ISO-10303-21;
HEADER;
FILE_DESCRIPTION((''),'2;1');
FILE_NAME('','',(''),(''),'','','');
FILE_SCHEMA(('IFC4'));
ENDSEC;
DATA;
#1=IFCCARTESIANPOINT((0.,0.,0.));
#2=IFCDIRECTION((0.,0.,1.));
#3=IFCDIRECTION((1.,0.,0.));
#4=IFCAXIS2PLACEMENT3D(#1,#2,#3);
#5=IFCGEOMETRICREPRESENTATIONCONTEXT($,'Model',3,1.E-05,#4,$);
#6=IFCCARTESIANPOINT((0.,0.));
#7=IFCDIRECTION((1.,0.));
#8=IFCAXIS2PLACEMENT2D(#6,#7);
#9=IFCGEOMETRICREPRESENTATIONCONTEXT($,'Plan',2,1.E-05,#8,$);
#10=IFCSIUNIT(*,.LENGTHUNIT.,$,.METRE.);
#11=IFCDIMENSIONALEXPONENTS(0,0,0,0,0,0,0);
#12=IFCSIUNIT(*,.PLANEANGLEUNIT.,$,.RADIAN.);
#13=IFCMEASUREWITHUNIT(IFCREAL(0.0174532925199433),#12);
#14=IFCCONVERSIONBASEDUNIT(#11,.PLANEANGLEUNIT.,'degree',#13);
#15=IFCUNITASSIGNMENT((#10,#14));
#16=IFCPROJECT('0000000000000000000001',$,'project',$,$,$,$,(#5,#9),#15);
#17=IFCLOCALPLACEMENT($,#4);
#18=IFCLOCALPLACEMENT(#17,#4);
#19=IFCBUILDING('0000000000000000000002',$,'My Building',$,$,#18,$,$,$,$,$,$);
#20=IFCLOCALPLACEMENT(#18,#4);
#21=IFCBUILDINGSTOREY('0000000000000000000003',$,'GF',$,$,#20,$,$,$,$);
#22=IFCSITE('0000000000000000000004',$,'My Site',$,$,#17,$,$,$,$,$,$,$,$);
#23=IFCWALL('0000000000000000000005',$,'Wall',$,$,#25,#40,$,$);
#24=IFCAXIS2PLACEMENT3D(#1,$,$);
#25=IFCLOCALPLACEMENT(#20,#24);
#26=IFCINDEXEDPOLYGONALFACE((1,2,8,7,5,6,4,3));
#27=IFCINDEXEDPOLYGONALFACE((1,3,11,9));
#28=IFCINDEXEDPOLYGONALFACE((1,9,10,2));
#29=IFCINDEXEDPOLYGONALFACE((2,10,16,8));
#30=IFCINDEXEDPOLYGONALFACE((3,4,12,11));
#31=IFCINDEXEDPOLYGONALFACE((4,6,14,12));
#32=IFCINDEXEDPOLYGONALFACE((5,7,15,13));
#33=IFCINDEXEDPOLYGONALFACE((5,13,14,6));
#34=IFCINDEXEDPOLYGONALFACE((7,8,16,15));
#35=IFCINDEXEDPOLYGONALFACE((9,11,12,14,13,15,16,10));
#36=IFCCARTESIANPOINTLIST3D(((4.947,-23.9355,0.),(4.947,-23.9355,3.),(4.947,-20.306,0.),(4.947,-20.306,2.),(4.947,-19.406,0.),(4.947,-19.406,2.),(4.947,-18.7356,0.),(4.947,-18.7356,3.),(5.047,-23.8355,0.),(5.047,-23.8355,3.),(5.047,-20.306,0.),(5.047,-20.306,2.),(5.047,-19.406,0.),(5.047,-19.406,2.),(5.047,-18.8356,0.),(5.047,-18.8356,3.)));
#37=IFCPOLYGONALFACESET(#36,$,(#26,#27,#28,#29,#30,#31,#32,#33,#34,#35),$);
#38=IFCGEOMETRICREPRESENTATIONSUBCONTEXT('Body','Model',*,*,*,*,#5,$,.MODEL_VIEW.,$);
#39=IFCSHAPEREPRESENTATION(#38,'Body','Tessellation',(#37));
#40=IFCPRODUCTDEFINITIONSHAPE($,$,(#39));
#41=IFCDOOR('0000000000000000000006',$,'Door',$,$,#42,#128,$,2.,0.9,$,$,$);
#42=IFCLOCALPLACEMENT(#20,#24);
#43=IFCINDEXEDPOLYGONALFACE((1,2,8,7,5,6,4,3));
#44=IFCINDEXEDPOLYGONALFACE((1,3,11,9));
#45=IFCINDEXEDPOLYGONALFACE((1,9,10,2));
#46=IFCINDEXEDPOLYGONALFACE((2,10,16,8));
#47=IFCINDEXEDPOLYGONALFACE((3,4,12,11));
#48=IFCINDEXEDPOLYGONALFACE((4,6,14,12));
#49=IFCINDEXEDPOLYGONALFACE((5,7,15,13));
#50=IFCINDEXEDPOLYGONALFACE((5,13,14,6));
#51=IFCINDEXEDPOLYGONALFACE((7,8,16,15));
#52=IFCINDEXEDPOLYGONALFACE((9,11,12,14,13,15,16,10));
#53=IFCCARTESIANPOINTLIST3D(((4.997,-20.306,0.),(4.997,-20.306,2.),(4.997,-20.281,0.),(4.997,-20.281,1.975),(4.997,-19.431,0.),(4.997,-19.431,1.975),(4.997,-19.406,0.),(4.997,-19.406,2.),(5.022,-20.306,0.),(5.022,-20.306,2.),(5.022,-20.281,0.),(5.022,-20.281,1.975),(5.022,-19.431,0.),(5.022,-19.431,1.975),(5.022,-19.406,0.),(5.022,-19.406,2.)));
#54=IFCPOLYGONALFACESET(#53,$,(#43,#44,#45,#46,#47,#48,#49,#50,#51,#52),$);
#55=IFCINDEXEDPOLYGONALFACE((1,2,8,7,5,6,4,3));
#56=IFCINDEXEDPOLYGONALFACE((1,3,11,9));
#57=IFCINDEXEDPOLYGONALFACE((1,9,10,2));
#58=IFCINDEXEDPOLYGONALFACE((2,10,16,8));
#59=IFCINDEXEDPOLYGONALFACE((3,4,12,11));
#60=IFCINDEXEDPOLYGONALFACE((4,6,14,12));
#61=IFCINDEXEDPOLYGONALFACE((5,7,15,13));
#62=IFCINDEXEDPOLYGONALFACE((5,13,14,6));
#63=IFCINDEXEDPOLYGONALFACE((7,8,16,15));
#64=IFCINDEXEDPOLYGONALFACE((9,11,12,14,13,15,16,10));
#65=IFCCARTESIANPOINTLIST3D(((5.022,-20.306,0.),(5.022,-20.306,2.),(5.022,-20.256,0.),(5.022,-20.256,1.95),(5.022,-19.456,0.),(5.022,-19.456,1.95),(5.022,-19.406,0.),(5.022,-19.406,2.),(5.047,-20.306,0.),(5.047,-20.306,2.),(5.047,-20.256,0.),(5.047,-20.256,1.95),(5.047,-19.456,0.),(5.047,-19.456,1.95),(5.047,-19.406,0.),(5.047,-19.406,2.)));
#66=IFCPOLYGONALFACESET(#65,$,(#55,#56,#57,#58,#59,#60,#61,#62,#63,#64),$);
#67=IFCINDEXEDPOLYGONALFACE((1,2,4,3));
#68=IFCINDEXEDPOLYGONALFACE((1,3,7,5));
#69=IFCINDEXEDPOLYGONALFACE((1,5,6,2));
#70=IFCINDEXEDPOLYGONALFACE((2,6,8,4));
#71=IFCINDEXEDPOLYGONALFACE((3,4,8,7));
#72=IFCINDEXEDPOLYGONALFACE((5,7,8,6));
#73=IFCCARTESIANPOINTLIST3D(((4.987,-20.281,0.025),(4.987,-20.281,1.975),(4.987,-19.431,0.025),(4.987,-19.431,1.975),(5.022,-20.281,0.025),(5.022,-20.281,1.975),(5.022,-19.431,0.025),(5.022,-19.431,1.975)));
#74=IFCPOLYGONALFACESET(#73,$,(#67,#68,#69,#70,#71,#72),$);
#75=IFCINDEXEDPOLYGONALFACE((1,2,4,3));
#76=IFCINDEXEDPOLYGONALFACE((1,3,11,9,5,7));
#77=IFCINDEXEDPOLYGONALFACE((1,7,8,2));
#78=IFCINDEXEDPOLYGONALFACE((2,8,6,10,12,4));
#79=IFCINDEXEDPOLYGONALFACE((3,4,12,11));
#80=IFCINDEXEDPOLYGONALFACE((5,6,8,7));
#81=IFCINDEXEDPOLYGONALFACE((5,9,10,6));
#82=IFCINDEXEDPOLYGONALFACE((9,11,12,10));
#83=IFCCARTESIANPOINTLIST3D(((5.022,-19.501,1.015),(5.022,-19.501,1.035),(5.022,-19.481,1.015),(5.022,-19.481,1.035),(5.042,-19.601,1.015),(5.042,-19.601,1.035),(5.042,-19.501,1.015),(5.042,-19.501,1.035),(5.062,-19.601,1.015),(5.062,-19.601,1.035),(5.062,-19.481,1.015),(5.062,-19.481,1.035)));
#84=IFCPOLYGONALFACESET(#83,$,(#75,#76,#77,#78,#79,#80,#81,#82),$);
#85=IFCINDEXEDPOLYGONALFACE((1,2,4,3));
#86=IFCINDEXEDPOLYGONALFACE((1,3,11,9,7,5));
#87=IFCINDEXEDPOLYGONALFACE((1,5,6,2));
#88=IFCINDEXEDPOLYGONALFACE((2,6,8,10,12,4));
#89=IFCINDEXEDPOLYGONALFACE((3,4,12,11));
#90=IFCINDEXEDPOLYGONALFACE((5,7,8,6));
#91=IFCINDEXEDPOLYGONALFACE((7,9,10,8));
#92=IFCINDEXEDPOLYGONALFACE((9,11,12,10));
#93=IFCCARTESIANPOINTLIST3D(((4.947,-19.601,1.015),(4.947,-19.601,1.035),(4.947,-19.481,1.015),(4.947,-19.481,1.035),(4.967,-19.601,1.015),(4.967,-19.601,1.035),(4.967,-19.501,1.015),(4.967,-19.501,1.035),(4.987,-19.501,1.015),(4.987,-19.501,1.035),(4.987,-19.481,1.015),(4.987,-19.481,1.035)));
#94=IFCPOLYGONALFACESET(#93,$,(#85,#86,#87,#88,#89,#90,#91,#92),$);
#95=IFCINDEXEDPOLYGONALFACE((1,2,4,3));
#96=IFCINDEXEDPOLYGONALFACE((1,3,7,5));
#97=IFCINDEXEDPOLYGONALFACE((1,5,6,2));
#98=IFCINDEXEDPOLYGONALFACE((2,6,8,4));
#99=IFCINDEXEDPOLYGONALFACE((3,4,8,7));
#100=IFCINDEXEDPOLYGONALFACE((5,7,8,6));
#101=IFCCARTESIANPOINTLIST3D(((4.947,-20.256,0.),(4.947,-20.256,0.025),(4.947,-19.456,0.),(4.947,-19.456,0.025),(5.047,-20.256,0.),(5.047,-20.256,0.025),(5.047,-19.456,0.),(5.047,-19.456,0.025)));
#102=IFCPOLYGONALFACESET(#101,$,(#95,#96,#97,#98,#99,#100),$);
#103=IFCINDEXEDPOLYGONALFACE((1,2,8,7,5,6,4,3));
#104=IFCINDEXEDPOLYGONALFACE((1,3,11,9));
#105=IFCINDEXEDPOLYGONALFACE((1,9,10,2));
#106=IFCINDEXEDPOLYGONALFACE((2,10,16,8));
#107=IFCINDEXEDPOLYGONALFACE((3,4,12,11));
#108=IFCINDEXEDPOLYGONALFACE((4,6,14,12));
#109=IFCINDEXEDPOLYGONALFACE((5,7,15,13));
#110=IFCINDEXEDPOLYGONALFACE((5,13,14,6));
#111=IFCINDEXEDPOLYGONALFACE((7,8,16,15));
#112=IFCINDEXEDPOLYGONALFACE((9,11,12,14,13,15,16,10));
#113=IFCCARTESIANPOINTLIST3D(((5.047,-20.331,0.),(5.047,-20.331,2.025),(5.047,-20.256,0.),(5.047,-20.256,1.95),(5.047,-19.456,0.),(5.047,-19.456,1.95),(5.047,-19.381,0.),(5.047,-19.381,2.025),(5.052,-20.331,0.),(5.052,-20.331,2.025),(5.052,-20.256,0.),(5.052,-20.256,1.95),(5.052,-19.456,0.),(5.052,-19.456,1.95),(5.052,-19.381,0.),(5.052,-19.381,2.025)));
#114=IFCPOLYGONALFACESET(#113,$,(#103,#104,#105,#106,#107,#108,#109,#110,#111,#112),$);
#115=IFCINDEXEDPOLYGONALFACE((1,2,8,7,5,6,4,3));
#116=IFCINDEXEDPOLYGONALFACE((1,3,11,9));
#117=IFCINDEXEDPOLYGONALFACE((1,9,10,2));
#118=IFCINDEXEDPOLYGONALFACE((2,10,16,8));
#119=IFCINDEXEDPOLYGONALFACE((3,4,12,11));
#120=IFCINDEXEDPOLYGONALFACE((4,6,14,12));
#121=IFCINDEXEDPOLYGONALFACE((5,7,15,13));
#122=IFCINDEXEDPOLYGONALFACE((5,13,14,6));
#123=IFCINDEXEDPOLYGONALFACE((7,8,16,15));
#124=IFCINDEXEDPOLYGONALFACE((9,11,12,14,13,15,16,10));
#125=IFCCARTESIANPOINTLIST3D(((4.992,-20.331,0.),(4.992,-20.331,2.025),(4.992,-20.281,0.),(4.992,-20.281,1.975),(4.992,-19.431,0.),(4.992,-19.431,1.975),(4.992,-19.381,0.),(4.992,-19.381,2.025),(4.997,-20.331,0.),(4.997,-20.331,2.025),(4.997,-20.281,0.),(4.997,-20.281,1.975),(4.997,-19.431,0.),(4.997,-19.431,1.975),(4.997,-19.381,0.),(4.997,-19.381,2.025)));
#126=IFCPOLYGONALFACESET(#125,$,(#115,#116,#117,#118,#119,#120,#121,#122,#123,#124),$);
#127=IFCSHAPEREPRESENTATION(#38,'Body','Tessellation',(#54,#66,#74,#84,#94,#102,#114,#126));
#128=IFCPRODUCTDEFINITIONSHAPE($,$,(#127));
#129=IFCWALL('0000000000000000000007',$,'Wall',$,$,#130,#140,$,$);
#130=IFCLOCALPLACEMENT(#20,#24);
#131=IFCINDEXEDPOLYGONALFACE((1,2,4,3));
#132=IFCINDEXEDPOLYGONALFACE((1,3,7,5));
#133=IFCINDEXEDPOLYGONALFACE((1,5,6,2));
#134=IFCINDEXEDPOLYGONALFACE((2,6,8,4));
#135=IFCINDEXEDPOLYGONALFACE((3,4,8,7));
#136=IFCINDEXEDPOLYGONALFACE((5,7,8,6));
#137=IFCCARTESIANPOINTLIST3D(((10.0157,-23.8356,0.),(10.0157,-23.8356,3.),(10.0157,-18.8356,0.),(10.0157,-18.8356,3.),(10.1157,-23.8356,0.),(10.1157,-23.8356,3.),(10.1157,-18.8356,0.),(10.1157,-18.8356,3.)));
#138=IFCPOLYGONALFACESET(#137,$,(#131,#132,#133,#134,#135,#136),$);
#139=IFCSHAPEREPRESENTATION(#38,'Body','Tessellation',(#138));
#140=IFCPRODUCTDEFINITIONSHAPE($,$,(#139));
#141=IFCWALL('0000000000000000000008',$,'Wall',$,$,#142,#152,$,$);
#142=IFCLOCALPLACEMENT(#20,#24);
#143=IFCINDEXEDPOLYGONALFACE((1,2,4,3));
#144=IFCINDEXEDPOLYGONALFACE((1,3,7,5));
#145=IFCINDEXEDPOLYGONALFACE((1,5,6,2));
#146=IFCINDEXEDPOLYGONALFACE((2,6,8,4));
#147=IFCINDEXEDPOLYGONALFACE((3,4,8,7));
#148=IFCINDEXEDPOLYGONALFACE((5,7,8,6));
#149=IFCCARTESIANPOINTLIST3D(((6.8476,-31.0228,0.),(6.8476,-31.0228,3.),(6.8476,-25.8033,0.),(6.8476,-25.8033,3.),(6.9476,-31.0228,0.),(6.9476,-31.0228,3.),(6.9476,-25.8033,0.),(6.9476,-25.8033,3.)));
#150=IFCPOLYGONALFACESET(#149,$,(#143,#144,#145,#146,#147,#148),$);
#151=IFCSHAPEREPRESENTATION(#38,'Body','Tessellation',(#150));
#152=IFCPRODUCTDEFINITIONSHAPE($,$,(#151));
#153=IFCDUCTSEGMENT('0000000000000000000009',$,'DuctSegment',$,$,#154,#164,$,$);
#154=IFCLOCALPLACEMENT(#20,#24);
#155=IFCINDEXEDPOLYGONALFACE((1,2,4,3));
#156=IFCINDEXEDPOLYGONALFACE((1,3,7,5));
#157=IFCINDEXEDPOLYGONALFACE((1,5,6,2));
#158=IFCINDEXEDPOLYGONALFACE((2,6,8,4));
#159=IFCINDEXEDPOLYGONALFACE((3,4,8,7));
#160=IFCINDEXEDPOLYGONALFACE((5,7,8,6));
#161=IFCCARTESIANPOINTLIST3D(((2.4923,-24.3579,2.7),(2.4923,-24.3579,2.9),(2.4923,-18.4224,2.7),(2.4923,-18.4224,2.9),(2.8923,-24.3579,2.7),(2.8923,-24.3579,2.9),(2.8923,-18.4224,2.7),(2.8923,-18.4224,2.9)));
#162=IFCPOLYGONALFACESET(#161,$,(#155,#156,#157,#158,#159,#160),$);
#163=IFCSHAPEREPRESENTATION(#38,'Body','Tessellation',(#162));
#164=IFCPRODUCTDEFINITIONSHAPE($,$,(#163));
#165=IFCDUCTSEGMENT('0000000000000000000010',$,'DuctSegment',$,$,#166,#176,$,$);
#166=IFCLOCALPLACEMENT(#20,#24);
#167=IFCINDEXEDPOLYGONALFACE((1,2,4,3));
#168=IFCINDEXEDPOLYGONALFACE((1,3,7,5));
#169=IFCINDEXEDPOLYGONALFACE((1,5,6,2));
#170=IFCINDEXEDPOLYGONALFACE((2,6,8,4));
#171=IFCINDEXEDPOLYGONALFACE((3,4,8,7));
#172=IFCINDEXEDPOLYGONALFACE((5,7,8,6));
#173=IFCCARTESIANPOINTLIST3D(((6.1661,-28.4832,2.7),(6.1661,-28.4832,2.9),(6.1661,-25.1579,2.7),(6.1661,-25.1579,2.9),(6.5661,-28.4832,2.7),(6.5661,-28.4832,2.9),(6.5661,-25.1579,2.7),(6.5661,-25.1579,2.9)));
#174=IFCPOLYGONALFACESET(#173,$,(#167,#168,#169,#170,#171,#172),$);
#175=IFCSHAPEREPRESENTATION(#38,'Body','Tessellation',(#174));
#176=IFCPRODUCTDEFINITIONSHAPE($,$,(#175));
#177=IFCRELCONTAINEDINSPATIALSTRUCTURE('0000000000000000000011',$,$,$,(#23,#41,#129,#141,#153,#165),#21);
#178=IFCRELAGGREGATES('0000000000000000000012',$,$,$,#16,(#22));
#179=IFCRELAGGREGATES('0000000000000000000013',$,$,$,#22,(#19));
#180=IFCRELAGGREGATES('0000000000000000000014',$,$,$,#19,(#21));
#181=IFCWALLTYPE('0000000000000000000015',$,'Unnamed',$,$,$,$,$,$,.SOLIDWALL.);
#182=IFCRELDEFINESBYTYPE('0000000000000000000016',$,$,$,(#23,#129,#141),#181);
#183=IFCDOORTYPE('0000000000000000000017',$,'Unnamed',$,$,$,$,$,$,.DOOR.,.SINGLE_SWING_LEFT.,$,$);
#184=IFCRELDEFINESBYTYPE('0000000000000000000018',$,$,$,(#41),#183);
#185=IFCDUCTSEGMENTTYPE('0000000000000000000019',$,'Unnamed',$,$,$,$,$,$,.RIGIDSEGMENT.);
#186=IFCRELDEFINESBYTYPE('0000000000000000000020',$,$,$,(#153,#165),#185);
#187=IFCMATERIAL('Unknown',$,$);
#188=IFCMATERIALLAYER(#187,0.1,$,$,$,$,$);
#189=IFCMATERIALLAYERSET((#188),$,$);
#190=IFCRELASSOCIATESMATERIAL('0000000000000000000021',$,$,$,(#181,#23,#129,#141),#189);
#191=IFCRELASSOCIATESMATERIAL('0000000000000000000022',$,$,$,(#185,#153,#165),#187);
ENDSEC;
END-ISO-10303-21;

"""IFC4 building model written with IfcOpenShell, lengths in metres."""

from ifc_helpers import new_model, entity, si_unit, converted_unit, frame, origin_with_axes, origin_2d_with_axis, place, context, subcontext, project, spatial, line, indexed_curve, rectangle, outline, extrude, shape, source, transform, mapped, material, layer, layer_set, layer_usage, material_profile, profile_set, profile_usage, type_object, type_shapes, element, fill, save


model = new_model("IFC4")

# Units and contexts
model_context = context("Model", 3, precision=1e-05, world=origin_with_axes())
plan_context = context("Plan", 2, precision=1e-05, world=origin_2d_with_axis())
body_context_1 = subcontext(model_context, "Body", "Model", "MODEL_VIEW")
body_context_2 = subcontext(plan_context, "Body", "Plan", "PLAN_VIEW")
ifc_project = project(units=[si_unit("LENGTHUNIT", "METRE"), converted_unit("PLANEANGLEUNIT", "degree", entity("IfcReal", 0.0174532925199433), si_unit("PLANEANGLEUNIT", "RADIAN"), dimensions=[0, 0, 0, 0, 0, 0, 0])], contexts=[model_context, plan_context])

# Site, building, storey
site_placement = place(None, origin_with_axes())
site = spatial("IfcSite", under=ifc_project, at=site_placement, Name="My Site")
building_placement = place(site_placement, origin_with_axes())
building = spatial("IfcBuilding", under=site, at=building_placement, Name="My Building")
storey_placement = place(building_placement, origin_with_axes())
storey = spatial("IfcBuildingStorey", under=building, at=storey_placement, Name="GF")

# Shared definitions
ifc_material = material(Name="Unknown")
ifc_layer = layer(ifc_material, 0.1)
ifc_layer_set = layer_set([ifc_layer])
wall_type = type_object("IfcWallType", Name="Unnamed", PredefinedType="SOLIDWALL", material=ifc_layer_set)

# Shared definitions
shared_shape_1 = source(origin_with_axes(), body_context_1, "Body", "SweptSolid", [
    extrude(outline(indexed_curve([(0.0, 0.0), (0.9, 0.0), (0.9, 2.0), (0.0, 2.0)], segments=[line(1, 2, 3, 4, 1)])), frame((0.0, -0.6, 0.0), z_axis=(0.0, -1.0, 0.0), x_axis=(1.0, 0.0, 0.0)), (0.0, 0.0, -1.0), 1.2),
])
door_type = type_object("IfcDoorType", Name="Unnamed", OperationType="SINGLE_SWING_LEFT", PredefinedType="DOOR")
shared_shape_2 = source(origin_with_axes(), body_context_1, "Body", "SweptSolid", [
    extrude(outline(indexed_curve([(0.0, 0.0), (0.0, 2.0), (0.9, 2.0), (0.9, 0.0), (0.875, 0.0), (0.875, 1.975), (0.025, 1.975), (0.025, 0.0)], segments=[line(1, 2, 3, 4, 5, 6, 7, 8, 1)])), frame((0.0, 0.025, 0.0), z_axis=(0.0, -1.0, 0.0), x_axis=(1.0, 0.0, 0.0)), (0.0, 0.0, -1.0), 0.025),
    extrude(outline(indexed_curve([(0.0, 0.0), (0.0, 2.0), (0.9, 2.0), (0.9, 0.0), (0.85, 0.0), (0.85, 1.95), (0.05, 1.95), (0.05, 0.0)], segments=[line(1, 2, 3, 4, 5, 6, 7, 8, 1)])), frame((0.0, 0.0, 0.0), z_axis=(0.0, -1.0, 0.0), x_axis=(1.0, 0.0, 0.0)), (0.0, 0.0, -1.0), 0.025),
    extrude(outline(indexed_curve([(0.0, 0.0), (0.85, 0.0), (0.85, 0.035), (0.0, 0.035)], segments=[line(1, 2, 3, 4, 1)])), frame((0.025, 0.025, 0.025), z_axis=(0.0, 0.0, 1.0), x_axis=(1.0, 0.0, 0.0)), (0.0, 0.0, 1.0), 1.95),
    extrude(outline(indexed_curve([(0.0, 0.0), (0.0, -0.04), (-0.12, -0.04), (-0.12, -0.02), (-0.02, -0.02), (-0.02, 0.0)], segments=[line(1, 2, 3, 4, 5, 6, 1)])), frame((0.825, 0.025, 1.015), z_axis=(0.0, 0.0, 1.0), x_axis=(1.0, 0.0, 0.0)), (0.0, 0.0, 1.0), 0.02),
    extrude(outline(indexed_curve([(0.0, 0.0), (0.0, 0.04), (-0.12, 0.04), (-0.12, 0.02), (-0.02, 0.02), (-0.02, 0.0)], segments=[line(1, 2, 3, 4, 5, 6, 1)])), frame((0.825, 0.06, 1.015), z_axis=(0.0, 0.0, 1.0), x_axis=(1.0, 0.0, 0.0)), (0.0, 0.0, 1.0), 0.02),
    extrude(outline(indexed_curve([(0.0, 0.0), (0.8, 0.0), (0.8, 0.1), (0.0, 0.1)], segments=[line(1, 2, 3, 4, 1)])), frame((0.05, 0.0, 0.0), z_axis=(0.0, 0.0, 1.0), x_axis=(1.0, 0.0, 0.0)), (0.0, 0.0, 1.0), 0.025),
    extrude(outline(indexed_curve([(0.0, 0.0), (0.0, 2.025), (0.95, 2.025), (0.95, 0.0), (0.875, 0.0), (0.875, 1.95), (0.075, 1.95), (0.075, 0.0)], segments=[line(1, 2, 3, 4, 5, 6, 7, 8, 1)])), frame((-0.025, -0.005, 0.0), z_axis=(0.0, -1.0, 0.0), x_axis=(1.0, 0.0, 0.0)), (0.0, 0.0, -1.0), 0.005),
    extrude(outline(indexed_curve([(0.0, 0.0), (0.0, 2.025), (0.95, 2.025), (0.95, 0.0), (0.9, 0.0), (0.9, 1.975), (0.05, 1.975), (0.05, 0.0)], segments=[line(1, 2, 3, 4, 5, 6, 7, 8, 1)])), frame((-0.025, 0.05, 0.0), z_axis=(0.0, -1.0, 0.0), x_axis=(1.0, 0.0, 0.0)), (0.0, 0.0, -1.0), 0.005),
])
shared_shape_3 = source(origin_with_axes(), body_context_2, "Body", "Curve2D", [
    entity("IfcIndexedPolyCurve", entity("IfcCartesianPointList2D", [[0.0, 0.0], [0.0, 0.05], [0.025, 0.05], [0.025, 0.025], [0.05, 0.025], [0.05, 0.0]]), [entity("IfcLineIndex", [1, 2, 3, 4, 5, 6, 1])]),
    entity("IfcIndexedPolyCurve", entity("IfcCartesianPointList2D", [[0.9, 0.0], [0.9, 0.05], [0.875, 0.05], [0.875, 0.025], [0.85, 0.025], [0.85, 0.0]]), [entity("IfcLineIndex", [1, 2, 3, 4, 5, 6, 1])]),
    entity("IfcTrimmedCurve", entity("IfcEllipse", entity("IfcAxis2Placement2D", entity("IfcCartesianPoint", [0.06, 0.05]), entity("IfcDirection", [1.0, 0.0])), 0.815, 0.85), [entity("IfcCartesianPoint", [0.875, 0.05])], [entity("IfcCartesianPoint", [0.06, 0.9])], True, "CARTESIAN"),
    entity("IfcIndexedPolyCurve", entity("IfcCartesianPointList2D", [[0.025, 0.05], [0.06, 0.05], [0.06, 0.9], [0.025, 0.9]]), [entity("IfcLineIndex", [1, 2, 3, 4, 1])]),
])
type_shapes(door_type, [shared_shape_2, shared_shape_3])

# Wall, opening, door
ifc_layer_usage_1 = layer_usage(ifc_layer_set, "AXIS2", "POSITIVE", 0.0)
wall_1_placement = place(storey_placement, frame((5.047, -23.8355, 0.0), z_axis=(0.0, 0.0, 1.0), x_axis=(0.0, 1.0, 0.0)))
wall_1 = element("IfcWall", 1, at=wall_1_placement, inside=storey, type_object=wall_type, material=ifc_layer_usage_1, Name="Wall", context=body_context_1, shape_type="SweptSolid", body=[
    extrude(outline(indexed_curve([(0.0, 0.0), (-0.1, 0.1), (5.1, 0.1), (5.0, 0.0)], segments=[line(1, 2, 3, 4, 1)])), origin_with_axes(), (0.0, 0.0, 1.0), 3.0),
])
opening_1_placement = place(wall_1_placement, frame((3.5295, 0.0, 0.0), z_axis=(0.0, 0.0, 1.0), x_axis=(1.0, 0.0, 0.0)))
opening_1 = element("IfcOpeningElement", 2, at=opening_1_placement, cuts=wall_1, PredefinedType="OPENING", context=body_context_1, shape_type="MappedRepresentation", body=[
    mapped(shared_shape_1, transform((0.0, 0.0, 0.0), x_axis=(1.0, 0.0, 0.0), y_axis=(0.0, 1.0, 0.0), z_axis=(0.0, 0.0, 1.0), scale=1.0)),
])
door_1_placement = place(opening_1_placement, frame((0.0, 0.0, 0.0), z_axis=(0.0, 0.0, 1.0), x_axis=(1.0, 0.0, 0.0)))
door_1 = element("IfcDoor", 3, at=door_1_placement, inside=storey, type_object=door_type, Name="Door", OverallHeight=2.0, OverallWidth=0.9, shapes=[
    shape(body_context_1, "Body", "MappedRepresentation", [mapped(shared_shape_2, transform((0.0, 0.0, 0.0), x_axis=(1.0, 0.0, 0.0), y_axis=(0.0, 1.0, 0.0), z_axis=(0.0, 0.0, 1.0), scale=1.0))]),
    shape(body_context_2, "Body", "MappedRepresentation", [mapped(shared_shape_3, transform((0.0, 0.0, 0.0), x_axis=(1.0, 0.0, 0.0), y_axis=(0.0, 1.0, 0.0), z_axis=(0.0, 0.0, 1.0), scale=1.0))]),
])
fill(opening_1, door_1)

# Walls
ifc_layer_usage_2 = layer_usage(ifc_layer_set, "AXIS2", "POSITIVE", 0.0)
wall_2_placement = place(storey_placement, frame((10.0157, -18.8356, 0.0), z_axis=(0.0, 0.0, 1.0), x_axis=(0.0, -1.0, 0.0)))
element("IfcWall", 4, at=wall_2_placement, inside=storey, type_object=wall_type, material=ifc_layer_usage_2, Name="Wall", context=body_context_1, shape_type="SweptSolid", body=[
    extrude(outline(indexed_curve([(0.0, 0.0), (0.0, 0.1), (5.0, 0.1), (5.0, 0.0)], segments=[line(1, 2, 3, 4, 1)])), origin_with_axes(), (0.0, 0.0, 1.0), 3.0),
])
ifc_layer_usage_3 = layer_usage(ifc_layer_set, "AXIS2", "POSITIVE", 0.0)
wall_3_placement = place(storey_placement, frame((6.8476, -25.8033, 0.0), z_axis=(0.0, 0.0, 1.0), x_axis=(0.0, -1.0, 0.0)))
element("IfcWall", 5, at=wall_3_placement, inside=storey, type_object=wall_type, material=ifc_layer_usage_3, Name="Wall", context=body_context_1, shape_type="SweptSolid", body=[
    extrude(outline(indexed_curve([(0.0, 0.0), (0.0, 0.1), (5.2195, 0.1), (5.2195, 0.0)], segments=[line(1, 2, 3, 4, 1)])), origin_with_axes(), (0.0, 0.0, 1.0), 3.0),
])

# Duct segments
ifc_material_profile_1 = material_profile(ifc_material, rectangle(XDim=0.4, YDim=0.2))
ifc_profile_set_1 = profile_set([ifc_material_profile_1])
ifc_profile_usage_1 = profile_usage(ifc_profile_set_1, cardinal=5)
duct_segment_type = type_object("IfcDuctSegmentType", Name="Unnamed", PredefinedType="RIGIDSEGMENT", material=ifc_profile_set_1)
duct_segment_1_placement = place(storey_placement, frame((2.6923, -24.3579, 2.8), z_axis=(0.0, 1.0, 0.0), x_axis=(-1.0, 0.0, 0.0)))
element("IfcDuctSegment", 6, at=duct_segment_1_placement, inside=storey, type_object=duct_segment_type, material=ifc_profile_usage_1, Name="DuctSegment", context=body_context_1, shape_type="SweptSolid", body=[
    extrude(rectangle(XDim=0.4, YDim=0.2), origin_with_axes(), (0.0, 0.0, 1.0), 5.9356),
])
ifc_profile_usage_2 = profile_usage(ifc_profile_set_1, cardinal=5)
duct_segment_2_placement = place(storey_placement, frame((6.3661, -25.1579, 2.8), z_axis=(0.0, -1.0, 0.0), x_axis=(1.0, 0.0, 0.0)))
element("IfcDuctSegment", 7, at=duct_segment_2_placement, inside=storey, type_object=duct_segment_type, material=ifc_profile_usage_2, Name="DuctSegment", context=body_context_1, shape_type="SweptSolid", body=[
    extrude(rectangle(XDim=0.4, YDim=0.2), origin_with_axes(), (0.0, 0.0, 1.0), 3.3252),
])

save(model, "model.ifc")
